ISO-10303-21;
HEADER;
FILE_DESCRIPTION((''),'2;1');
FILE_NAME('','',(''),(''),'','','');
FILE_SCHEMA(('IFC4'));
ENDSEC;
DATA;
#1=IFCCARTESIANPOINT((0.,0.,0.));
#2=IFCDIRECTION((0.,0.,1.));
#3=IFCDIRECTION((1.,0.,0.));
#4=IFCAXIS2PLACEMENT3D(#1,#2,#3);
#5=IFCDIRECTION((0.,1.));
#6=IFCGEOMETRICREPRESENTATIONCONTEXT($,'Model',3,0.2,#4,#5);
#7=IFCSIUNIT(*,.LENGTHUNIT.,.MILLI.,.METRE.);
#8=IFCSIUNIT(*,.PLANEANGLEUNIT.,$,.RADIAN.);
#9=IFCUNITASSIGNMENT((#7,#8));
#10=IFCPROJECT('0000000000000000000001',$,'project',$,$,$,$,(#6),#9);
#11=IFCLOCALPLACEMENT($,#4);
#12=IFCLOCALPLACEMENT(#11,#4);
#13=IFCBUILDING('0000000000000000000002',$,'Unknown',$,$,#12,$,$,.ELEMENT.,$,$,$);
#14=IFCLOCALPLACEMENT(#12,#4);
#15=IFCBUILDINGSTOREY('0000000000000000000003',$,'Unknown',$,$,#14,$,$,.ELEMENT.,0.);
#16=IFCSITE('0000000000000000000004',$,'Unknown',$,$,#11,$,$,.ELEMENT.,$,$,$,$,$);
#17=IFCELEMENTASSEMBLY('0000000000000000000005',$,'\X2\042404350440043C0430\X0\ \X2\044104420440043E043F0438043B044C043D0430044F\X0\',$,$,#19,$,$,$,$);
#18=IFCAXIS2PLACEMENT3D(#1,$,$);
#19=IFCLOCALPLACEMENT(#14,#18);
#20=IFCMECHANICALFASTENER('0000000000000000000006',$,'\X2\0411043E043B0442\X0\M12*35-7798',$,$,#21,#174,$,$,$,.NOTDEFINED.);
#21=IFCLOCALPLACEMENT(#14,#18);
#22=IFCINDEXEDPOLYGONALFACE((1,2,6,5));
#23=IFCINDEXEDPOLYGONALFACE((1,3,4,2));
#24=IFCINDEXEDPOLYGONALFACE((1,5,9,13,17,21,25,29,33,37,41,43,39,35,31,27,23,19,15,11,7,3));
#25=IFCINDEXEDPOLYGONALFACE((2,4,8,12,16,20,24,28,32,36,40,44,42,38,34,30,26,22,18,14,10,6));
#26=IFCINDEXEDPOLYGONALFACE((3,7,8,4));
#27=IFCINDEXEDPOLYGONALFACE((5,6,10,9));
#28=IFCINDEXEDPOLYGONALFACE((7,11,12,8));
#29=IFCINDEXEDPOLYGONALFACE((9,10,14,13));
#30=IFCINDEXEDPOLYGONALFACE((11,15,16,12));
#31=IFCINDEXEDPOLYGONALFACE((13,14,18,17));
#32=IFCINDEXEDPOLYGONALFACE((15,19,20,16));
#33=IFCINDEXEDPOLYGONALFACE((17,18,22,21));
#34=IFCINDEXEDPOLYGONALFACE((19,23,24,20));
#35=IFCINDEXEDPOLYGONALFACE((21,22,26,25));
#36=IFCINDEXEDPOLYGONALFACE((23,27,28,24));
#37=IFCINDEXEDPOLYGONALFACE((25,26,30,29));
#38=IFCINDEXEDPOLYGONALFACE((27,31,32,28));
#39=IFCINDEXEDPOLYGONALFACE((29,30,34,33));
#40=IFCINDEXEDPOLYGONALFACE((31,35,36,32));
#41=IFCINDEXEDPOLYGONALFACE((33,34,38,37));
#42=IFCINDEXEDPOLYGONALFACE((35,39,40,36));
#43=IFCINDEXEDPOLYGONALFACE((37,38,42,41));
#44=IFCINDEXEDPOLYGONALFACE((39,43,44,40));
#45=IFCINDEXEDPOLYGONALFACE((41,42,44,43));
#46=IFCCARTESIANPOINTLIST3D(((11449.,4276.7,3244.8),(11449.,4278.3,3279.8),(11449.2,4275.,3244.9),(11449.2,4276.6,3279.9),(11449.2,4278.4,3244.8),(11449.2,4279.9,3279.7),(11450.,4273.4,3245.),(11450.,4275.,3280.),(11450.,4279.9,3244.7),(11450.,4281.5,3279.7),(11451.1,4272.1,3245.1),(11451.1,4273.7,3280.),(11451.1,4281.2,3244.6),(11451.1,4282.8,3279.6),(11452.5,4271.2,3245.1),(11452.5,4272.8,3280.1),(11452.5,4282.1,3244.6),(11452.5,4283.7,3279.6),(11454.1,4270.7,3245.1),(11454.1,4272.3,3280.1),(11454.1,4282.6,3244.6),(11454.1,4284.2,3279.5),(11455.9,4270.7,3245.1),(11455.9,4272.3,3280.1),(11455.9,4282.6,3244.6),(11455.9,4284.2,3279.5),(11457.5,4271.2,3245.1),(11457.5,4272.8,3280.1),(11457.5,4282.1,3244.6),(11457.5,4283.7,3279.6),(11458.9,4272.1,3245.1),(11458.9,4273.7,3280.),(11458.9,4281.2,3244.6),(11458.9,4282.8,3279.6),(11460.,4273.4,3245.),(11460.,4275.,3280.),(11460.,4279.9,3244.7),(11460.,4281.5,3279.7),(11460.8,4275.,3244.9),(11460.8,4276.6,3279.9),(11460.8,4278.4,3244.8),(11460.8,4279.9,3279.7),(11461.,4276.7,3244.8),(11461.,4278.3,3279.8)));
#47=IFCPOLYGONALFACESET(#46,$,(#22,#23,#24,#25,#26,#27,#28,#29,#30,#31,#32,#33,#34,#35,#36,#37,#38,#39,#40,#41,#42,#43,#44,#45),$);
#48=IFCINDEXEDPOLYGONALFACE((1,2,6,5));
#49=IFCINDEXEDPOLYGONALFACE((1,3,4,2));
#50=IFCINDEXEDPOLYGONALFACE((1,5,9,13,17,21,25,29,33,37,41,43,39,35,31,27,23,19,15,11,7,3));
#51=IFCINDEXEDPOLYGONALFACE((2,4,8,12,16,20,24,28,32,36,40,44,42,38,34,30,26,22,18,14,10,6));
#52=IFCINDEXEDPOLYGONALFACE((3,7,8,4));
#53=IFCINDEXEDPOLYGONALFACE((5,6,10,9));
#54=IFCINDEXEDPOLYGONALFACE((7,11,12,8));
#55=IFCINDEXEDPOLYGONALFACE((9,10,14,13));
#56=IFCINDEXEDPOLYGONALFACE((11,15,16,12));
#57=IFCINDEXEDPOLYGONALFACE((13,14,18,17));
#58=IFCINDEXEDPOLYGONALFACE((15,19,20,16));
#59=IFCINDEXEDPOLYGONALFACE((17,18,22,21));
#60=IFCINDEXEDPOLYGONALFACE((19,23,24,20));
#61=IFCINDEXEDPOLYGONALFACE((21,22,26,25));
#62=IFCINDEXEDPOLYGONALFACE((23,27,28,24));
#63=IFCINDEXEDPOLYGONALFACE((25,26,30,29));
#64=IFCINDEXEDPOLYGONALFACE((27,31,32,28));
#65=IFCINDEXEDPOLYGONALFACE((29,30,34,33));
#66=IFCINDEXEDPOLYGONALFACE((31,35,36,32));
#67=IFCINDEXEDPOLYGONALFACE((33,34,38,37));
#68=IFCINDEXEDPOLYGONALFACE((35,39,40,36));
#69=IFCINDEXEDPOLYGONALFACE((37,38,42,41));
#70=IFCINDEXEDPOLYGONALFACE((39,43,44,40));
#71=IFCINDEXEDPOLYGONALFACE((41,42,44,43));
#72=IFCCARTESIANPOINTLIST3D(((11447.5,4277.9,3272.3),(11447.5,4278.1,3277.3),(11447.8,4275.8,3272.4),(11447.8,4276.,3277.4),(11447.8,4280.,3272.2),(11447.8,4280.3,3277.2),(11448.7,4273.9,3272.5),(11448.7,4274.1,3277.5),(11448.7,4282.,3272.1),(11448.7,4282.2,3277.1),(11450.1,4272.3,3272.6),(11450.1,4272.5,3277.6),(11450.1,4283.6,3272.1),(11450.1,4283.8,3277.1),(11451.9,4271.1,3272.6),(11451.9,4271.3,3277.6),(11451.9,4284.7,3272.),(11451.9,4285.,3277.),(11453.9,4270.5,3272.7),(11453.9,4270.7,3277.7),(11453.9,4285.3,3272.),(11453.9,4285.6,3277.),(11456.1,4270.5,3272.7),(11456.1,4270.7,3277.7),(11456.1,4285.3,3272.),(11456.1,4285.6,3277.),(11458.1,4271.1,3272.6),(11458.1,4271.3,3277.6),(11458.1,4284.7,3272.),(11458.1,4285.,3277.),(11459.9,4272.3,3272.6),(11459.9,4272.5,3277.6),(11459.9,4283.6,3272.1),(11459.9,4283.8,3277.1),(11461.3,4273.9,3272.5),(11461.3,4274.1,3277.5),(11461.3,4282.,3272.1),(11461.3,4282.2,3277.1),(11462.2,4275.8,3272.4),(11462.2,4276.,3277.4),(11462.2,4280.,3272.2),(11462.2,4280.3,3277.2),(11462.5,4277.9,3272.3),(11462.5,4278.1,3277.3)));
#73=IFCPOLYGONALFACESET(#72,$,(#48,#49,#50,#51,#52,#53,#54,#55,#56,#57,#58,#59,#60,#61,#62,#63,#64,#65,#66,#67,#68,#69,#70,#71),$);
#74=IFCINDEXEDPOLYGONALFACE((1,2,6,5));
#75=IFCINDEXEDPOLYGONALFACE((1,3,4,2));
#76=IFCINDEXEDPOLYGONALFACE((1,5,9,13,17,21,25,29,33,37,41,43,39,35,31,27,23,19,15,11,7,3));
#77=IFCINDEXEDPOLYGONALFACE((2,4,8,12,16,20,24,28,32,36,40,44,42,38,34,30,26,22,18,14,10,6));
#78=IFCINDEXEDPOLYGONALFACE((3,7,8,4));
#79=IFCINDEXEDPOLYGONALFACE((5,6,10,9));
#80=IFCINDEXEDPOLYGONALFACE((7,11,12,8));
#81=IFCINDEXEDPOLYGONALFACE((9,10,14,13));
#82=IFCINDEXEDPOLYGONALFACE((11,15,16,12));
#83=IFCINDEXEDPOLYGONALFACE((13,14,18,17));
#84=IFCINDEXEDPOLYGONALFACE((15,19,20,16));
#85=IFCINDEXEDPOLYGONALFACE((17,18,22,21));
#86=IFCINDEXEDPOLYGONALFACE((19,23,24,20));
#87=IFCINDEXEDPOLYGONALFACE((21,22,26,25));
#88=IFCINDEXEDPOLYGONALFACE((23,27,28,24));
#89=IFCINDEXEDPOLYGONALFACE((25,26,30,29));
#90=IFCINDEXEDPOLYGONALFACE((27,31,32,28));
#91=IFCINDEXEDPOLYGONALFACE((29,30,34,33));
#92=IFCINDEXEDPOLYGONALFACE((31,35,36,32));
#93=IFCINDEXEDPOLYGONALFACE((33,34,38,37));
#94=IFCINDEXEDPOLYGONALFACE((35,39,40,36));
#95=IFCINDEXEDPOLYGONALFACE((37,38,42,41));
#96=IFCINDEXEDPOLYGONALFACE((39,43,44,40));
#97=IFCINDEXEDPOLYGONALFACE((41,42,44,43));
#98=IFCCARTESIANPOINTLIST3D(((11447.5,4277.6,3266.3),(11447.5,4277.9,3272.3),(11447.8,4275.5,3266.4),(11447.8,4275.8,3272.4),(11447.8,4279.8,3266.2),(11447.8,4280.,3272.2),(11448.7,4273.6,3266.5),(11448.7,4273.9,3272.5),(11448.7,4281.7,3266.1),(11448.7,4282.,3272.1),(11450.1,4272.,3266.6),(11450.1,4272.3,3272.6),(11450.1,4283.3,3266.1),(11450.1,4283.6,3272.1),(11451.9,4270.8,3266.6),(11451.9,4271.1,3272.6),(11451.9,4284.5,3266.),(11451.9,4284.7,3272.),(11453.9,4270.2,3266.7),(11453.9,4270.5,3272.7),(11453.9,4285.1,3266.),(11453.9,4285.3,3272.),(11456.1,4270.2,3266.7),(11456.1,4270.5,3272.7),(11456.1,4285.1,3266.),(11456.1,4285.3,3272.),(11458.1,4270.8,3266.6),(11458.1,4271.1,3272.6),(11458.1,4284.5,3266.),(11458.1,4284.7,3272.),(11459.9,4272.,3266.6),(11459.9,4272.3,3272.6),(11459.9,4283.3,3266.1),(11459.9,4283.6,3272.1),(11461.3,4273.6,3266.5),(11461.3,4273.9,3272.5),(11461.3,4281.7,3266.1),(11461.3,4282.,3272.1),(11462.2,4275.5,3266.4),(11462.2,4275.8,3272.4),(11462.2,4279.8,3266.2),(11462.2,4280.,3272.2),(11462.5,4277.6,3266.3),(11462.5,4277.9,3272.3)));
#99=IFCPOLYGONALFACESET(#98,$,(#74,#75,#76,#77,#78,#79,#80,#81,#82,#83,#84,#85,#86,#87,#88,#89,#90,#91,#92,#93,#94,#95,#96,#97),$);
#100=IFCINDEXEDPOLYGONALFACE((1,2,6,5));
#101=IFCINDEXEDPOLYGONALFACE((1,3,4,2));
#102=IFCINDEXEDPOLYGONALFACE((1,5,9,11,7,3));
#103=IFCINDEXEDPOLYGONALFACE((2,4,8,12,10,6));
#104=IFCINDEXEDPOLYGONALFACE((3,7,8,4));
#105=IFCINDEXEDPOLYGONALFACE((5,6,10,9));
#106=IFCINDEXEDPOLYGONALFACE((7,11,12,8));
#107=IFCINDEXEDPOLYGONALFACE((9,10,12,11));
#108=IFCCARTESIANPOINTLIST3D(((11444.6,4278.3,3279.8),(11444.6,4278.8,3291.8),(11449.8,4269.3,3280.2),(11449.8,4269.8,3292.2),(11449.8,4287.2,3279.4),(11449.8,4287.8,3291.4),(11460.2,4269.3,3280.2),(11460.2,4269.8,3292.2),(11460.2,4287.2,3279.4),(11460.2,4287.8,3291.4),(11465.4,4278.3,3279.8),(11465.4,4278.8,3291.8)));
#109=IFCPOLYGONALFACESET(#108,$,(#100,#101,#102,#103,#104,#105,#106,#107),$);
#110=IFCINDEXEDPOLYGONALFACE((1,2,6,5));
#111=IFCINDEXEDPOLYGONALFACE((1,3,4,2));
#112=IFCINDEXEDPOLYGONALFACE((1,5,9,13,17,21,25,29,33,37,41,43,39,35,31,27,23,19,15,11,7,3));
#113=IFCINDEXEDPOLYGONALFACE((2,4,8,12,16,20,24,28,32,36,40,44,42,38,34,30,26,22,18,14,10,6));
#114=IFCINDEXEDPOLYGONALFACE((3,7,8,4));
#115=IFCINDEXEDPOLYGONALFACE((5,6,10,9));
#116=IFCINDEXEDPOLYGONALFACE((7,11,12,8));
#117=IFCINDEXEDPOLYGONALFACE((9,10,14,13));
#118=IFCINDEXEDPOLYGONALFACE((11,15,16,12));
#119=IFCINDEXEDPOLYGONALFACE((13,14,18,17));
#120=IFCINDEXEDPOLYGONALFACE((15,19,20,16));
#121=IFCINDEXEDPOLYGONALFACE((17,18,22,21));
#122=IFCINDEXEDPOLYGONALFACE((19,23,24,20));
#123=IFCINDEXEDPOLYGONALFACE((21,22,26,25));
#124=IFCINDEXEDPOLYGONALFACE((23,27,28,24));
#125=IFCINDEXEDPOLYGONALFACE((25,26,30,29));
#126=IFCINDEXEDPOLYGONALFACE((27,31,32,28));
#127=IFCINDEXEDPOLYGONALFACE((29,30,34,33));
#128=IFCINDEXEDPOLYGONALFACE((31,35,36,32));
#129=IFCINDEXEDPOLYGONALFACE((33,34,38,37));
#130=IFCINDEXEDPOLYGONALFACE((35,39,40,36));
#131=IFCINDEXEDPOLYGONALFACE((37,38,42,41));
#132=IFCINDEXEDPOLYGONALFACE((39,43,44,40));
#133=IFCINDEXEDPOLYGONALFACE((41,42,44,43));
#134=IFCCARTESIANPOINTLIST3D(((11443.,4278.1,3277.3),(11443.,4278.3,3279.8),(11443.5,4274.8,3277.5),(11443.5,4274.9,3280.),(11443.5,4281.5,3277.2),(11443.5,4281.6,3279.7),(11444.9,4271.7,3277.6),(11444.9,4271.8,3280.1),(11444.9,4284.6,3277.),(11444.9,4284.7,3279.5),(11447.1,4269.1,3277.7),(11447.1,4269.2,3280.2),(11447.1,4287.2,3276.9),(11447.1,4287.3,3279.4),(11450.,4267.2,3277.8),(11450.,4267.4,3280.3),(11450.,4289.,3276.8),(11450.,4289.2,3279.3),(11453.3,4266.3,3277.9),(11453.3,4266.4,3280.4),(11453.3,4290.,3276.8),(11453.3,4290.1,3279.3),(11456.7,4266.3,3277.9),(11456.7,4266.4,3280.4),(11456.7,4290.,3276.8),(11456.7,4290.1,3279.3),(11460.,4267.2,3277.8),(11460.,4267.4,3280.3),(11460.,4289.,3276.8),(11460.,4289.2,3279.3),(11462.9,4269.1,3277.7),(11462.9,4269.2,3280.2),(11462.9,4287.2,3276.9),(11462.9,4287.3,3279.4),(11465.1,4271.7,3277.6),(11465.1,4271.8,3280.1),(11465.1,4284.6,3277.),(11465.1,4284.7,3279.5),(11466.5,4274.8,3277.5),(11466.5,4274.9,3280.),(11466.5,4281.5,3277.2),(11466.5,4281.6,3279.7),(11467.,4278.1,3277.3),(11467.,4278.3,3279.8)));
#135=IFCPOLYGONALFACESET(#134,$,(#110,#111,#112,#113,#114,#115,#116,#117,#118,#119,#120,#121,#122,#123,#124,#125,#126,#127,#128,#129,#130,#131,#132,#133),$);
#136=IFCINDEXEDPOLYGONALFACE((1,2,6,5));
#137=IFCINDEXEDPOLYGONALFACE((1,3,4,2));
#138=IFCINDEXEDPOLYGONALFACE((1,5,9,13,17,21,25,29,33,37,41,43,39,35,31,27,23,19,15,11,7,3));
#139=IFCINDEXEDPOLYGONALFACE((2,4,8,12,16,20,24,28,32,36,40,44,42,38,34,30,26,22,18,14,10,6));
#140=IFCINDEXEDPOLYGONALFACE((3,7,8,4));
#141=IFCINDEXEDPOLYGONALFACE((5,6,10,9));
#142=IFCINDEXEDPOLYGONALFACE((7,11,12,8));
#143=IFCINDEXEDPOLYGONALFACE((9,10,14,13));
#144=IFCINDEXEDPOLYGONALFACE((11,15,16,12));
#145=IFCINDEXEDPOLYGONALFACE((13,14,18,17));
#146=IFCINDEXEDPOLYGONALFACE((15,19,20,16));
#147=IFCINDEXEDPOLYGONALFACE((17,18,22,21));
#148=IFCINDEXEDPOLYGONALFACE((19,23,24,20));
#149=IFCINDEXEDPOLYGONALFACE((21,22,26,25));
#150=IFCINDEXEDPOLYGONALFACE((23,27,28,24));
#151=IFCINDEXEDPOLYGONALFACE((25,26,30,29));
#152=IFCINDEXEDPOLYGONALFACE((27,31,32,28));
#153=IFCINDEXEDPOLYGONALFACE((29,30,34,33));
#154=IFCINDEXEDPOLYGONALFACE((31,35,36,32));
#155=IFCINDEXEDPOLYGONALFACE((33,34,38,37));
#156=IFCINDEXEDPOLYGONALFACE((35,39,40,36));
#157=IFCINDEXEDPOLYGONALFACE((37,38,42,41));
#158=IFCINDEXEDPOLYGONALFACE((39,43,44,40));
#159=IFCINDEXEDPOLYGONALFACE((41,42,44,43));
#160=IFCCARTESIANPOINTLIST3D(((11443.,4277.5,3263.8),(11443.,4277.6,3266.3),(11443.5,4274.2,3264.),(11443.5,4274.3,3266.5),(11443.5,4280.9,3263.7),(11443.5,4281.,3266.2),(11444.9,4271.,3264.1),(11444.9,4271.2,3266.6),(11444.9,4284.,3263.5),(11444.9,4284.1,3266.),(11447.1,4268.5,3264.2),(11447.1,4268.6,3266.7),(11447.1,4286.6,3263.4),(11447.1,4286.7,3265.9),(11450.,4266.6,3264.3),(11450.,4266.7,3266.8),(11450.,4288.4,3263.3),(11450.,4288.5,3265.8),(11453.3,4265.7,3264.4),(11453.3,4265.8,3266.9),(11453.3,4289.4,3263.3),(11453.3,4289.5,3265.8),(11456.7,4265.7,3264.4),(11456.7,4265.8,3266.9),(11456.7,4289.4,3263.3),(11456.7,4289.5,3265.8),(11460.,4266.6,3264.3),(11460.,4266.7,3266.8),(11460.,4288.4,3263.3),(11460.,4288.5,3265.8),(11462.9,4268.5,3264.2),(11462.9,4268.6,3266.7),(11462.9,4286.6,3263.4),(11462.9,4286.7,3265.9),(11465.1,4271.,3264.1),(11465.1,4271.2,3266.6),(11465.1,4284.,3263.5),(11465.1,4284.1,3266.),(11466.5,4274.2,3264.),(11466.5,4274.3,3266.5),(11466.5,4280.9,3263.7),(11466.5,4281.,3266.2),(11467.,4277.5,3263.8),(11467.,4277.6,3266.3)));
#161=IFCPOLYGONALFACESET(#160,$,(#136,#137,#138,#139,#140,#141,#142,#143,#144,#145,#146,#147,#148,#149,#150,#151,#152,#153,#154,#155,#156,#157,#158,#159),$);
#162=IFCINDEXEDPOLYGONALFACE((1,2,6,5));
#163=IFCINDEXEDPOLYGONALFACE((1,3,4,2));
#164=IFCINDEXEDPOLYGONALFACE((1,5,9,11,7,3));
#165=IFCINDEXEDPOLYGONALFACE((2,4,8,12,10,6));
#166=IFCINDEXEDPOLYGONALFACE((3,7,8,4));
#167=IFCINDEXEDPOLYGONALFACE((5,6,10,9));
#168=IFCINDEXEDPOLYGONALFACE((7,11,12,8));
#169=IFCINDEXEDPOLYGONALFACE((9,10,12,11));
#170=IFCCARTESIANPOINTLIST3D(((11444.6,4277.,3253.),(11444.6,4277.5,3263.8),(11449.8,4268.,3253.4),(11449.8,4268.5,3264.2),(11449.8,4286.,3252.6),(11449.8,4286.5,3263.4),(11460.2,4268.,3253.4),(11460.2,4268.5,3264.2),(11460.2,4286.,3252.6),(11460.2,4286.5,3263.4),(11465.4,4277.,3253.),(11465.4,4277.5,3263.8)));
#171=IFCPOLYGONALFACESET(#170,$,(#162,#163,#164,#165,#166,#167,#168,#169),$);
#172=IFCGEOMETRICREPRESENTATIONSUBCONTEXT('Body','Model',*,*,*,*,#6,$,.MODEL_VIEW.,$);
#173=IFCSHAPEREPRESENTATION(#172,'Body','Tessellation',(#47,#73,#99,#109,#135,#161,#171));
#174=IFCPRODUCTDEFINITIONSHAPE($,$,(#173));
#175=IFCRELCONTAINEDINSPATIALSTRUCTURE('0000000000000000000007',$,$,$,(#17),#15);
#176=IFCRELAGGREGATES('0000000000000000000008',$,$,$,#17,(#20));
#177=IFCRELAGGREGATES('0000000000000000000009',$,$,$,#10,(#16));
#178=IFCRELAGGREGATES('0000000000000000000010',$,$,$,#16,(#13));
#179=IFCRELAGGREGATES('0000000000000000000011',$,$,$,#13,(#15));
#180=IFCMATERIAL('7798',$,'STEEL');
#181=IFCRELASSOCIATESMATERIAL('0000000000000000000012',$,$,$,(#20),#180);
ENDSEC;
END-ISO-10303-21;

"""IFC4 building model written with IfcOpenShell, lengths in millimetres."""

from ifc_helpers import new_model, si_unit, direction, frame, origin_with_axes, place, context, subcontext, project, spatial, line, arc, indexed_curve, outline, extrude, source, transform, mapped, material, element, aggregate, save


model = new_model("IFC4")

# Units and contexts
model_context = context("Model", 3, precision=0.2, world=origin_with_axes(), true_north=direction((0.0, 1.0)))
body_context = subcontext(model_context, "Body", "Model", "MODEL_VIEW")
ifc_project = project(units=[si_unit("LENGTHUNIT", "METRE", prefix="MILLI"), si_unit("PLANEANGLEUNIT", "RADIAN")], contexts=[model_context])

# Site, building, storey
site_placement = place(None, origin_with_axes())
site = spatial("IfcSite", under=ifc_project, at=site_placement, Name="Unknown", CompositionType="ELEMENT")
building_placement = place(site_placement, origin_with_axes())
building = spatial("IfcBuilding", under=site, at=building_placement, Name="Unknown", CompositionType="ELEMENT")
storey_placement = place(building_placement, origin_with_axes())
storey = spatial("IfcBuildingStorey", under=building, at=storey_placement, Name="Unknown", CompositionType="ELEMENT", Elevation=0.0)

# Element assembly
assembly_1_placement = place(storey_placement, frame((11400.0, 88.6, 3426.7), z_axis=(1.0, 0.0, 0.0), x_axis=(0.0, 0.998969, -0.045408)))
assembly_1 = element("IfcElementAssembly", 1, at=assembly_1_placement, inside=storey, Name="Ферма стропильная")

# Mechanical fastener
ifc_material_1 = material(Name="7798", Category="STEEL")
shared_shape_1 = source(origin_with_axes(), body_context, "Body", "SweptSolid", [
    extrude(outline(indexed_curve([(6.0, 0.0), (0.0, 6.0), (-6.0, 0.0), (0.0, -6.0)], segments=[arc(1, 2, 3), arc(3, 4, 1)])), frame((0.0, 0.0, 7.5), z_axis=(0.0, 0.0, -1.0), x_axis=(0.0, 1.0, 0.0)), (0.0, 0.0, 1.0), 35.0),
    extrude(outline(indexed_curve([(7.5, 0.0), (0.0, 7.5), (-7.5, 0.0), (0.0, -7.5)], segments=[arc(1, 2, 3), arc(3, 4, 1)])), frame((0.0, 0.0, 5.0), z_axis=(0.0, 0.0, -1.0), x_axis=(0.0, 1.0, 0.0)), (0.0, 0.0, 1.0), 5.0),
    extrude(outline(indexed_curve([(7.5, 0.0), (0.0, 7.5), (-7.5, 0.0), (0.0, -7.5)], segments=[arc(1, 2, 3), arc(3, 4, 1)])), frame((0.0, 0.0, 0.0), z_axis=(0.0, 0.0, -1.0), x_axis=(0.0, 1.0, 0.0)), (0.0, 0.0, 1.0), 6.0),
    extrude(outline(indexed_curve([(10.4, 0.0), (5.2, 9.0), (-5.2, 9.0), (-10.4, 0.0), (-5.2, -9.0), (5.2, -9.0)], segments=[line(1, 2, 3, 4, 5, 6, 1)])), frame((0.0, 0.0, 19.5), z_axis=(0.0, 0.0, -1.0), x_axis=(0.0, 1.0, 0.0)), (0.0, 0.0, 1.0), 12.0),
    extrude(outline(indexed_curve([(12.0, 0.0), (0.0, 12.0), (-12.0, 0.0), (0.0, -12.0)], segments=[arc(1, 2, 3), arc(3, 4, 1)])), frame((0.0, 0.0, 7.5), z_axis=(0.0, 0.0, -1.0), x_axis=(0.0, 1.0, 0.0)), (0.0, 0.0, 1.0), 2.5),
    extrude(outline(indexed_curve([(12.0, 0.0), (0.0, 12.0), (-12.0, 0.0), (0.0, -12.0)], segments=[arc(1, 2, 3), arc(3, 4, 1)])), frame((0.0, 0.0, -6.0), z_axis=(0.0, 0.0, -1.0), x_axis=(0.0, 1.0, 0.0)), (0.0, 0.0, 1.0), 2.5),
    extrude(outline(indexed_curve([(10.4, 0.0), (5.2, 9.0), (-5.2, 9.0), (-10.4, 0.0), (-5.2, -9.0), (5.2, -9.0)], segments=[line(1, 2, 3, 4, 5, 6, 1)])), frame((0.0, 0.0, -8.5), z_axis=(0.0, 0.0, -1.0), x_axis=(0.0, 1.0, 0.0)), (0.0, 0.0, 1.0), 10.8),
])
mechanical_fastener_1_placement = place(assembly_1_placement, frame((4192.0, 36.0, 55.0), z_axis=(0.0, 1.0, 0.0), x_axis=(-1.0, 0.0, 0.0)))
mechanical_fastener_1 = element("IfcMechanicalFastener", 2, at=mechanical_fastener_1_placement, material=ifc_material_1, Name="БолтM12*35-7798", PredefinedType="NOTDEFINED", context=body_context, shape_type="MappedRepresentation", body=[
    mapped(shared_shape_1, transform((0.0, 0.0, 0.0))),
])
aggregate(assembly_1, [mechanical_fastener_1])

save(model, "model.ifc")
